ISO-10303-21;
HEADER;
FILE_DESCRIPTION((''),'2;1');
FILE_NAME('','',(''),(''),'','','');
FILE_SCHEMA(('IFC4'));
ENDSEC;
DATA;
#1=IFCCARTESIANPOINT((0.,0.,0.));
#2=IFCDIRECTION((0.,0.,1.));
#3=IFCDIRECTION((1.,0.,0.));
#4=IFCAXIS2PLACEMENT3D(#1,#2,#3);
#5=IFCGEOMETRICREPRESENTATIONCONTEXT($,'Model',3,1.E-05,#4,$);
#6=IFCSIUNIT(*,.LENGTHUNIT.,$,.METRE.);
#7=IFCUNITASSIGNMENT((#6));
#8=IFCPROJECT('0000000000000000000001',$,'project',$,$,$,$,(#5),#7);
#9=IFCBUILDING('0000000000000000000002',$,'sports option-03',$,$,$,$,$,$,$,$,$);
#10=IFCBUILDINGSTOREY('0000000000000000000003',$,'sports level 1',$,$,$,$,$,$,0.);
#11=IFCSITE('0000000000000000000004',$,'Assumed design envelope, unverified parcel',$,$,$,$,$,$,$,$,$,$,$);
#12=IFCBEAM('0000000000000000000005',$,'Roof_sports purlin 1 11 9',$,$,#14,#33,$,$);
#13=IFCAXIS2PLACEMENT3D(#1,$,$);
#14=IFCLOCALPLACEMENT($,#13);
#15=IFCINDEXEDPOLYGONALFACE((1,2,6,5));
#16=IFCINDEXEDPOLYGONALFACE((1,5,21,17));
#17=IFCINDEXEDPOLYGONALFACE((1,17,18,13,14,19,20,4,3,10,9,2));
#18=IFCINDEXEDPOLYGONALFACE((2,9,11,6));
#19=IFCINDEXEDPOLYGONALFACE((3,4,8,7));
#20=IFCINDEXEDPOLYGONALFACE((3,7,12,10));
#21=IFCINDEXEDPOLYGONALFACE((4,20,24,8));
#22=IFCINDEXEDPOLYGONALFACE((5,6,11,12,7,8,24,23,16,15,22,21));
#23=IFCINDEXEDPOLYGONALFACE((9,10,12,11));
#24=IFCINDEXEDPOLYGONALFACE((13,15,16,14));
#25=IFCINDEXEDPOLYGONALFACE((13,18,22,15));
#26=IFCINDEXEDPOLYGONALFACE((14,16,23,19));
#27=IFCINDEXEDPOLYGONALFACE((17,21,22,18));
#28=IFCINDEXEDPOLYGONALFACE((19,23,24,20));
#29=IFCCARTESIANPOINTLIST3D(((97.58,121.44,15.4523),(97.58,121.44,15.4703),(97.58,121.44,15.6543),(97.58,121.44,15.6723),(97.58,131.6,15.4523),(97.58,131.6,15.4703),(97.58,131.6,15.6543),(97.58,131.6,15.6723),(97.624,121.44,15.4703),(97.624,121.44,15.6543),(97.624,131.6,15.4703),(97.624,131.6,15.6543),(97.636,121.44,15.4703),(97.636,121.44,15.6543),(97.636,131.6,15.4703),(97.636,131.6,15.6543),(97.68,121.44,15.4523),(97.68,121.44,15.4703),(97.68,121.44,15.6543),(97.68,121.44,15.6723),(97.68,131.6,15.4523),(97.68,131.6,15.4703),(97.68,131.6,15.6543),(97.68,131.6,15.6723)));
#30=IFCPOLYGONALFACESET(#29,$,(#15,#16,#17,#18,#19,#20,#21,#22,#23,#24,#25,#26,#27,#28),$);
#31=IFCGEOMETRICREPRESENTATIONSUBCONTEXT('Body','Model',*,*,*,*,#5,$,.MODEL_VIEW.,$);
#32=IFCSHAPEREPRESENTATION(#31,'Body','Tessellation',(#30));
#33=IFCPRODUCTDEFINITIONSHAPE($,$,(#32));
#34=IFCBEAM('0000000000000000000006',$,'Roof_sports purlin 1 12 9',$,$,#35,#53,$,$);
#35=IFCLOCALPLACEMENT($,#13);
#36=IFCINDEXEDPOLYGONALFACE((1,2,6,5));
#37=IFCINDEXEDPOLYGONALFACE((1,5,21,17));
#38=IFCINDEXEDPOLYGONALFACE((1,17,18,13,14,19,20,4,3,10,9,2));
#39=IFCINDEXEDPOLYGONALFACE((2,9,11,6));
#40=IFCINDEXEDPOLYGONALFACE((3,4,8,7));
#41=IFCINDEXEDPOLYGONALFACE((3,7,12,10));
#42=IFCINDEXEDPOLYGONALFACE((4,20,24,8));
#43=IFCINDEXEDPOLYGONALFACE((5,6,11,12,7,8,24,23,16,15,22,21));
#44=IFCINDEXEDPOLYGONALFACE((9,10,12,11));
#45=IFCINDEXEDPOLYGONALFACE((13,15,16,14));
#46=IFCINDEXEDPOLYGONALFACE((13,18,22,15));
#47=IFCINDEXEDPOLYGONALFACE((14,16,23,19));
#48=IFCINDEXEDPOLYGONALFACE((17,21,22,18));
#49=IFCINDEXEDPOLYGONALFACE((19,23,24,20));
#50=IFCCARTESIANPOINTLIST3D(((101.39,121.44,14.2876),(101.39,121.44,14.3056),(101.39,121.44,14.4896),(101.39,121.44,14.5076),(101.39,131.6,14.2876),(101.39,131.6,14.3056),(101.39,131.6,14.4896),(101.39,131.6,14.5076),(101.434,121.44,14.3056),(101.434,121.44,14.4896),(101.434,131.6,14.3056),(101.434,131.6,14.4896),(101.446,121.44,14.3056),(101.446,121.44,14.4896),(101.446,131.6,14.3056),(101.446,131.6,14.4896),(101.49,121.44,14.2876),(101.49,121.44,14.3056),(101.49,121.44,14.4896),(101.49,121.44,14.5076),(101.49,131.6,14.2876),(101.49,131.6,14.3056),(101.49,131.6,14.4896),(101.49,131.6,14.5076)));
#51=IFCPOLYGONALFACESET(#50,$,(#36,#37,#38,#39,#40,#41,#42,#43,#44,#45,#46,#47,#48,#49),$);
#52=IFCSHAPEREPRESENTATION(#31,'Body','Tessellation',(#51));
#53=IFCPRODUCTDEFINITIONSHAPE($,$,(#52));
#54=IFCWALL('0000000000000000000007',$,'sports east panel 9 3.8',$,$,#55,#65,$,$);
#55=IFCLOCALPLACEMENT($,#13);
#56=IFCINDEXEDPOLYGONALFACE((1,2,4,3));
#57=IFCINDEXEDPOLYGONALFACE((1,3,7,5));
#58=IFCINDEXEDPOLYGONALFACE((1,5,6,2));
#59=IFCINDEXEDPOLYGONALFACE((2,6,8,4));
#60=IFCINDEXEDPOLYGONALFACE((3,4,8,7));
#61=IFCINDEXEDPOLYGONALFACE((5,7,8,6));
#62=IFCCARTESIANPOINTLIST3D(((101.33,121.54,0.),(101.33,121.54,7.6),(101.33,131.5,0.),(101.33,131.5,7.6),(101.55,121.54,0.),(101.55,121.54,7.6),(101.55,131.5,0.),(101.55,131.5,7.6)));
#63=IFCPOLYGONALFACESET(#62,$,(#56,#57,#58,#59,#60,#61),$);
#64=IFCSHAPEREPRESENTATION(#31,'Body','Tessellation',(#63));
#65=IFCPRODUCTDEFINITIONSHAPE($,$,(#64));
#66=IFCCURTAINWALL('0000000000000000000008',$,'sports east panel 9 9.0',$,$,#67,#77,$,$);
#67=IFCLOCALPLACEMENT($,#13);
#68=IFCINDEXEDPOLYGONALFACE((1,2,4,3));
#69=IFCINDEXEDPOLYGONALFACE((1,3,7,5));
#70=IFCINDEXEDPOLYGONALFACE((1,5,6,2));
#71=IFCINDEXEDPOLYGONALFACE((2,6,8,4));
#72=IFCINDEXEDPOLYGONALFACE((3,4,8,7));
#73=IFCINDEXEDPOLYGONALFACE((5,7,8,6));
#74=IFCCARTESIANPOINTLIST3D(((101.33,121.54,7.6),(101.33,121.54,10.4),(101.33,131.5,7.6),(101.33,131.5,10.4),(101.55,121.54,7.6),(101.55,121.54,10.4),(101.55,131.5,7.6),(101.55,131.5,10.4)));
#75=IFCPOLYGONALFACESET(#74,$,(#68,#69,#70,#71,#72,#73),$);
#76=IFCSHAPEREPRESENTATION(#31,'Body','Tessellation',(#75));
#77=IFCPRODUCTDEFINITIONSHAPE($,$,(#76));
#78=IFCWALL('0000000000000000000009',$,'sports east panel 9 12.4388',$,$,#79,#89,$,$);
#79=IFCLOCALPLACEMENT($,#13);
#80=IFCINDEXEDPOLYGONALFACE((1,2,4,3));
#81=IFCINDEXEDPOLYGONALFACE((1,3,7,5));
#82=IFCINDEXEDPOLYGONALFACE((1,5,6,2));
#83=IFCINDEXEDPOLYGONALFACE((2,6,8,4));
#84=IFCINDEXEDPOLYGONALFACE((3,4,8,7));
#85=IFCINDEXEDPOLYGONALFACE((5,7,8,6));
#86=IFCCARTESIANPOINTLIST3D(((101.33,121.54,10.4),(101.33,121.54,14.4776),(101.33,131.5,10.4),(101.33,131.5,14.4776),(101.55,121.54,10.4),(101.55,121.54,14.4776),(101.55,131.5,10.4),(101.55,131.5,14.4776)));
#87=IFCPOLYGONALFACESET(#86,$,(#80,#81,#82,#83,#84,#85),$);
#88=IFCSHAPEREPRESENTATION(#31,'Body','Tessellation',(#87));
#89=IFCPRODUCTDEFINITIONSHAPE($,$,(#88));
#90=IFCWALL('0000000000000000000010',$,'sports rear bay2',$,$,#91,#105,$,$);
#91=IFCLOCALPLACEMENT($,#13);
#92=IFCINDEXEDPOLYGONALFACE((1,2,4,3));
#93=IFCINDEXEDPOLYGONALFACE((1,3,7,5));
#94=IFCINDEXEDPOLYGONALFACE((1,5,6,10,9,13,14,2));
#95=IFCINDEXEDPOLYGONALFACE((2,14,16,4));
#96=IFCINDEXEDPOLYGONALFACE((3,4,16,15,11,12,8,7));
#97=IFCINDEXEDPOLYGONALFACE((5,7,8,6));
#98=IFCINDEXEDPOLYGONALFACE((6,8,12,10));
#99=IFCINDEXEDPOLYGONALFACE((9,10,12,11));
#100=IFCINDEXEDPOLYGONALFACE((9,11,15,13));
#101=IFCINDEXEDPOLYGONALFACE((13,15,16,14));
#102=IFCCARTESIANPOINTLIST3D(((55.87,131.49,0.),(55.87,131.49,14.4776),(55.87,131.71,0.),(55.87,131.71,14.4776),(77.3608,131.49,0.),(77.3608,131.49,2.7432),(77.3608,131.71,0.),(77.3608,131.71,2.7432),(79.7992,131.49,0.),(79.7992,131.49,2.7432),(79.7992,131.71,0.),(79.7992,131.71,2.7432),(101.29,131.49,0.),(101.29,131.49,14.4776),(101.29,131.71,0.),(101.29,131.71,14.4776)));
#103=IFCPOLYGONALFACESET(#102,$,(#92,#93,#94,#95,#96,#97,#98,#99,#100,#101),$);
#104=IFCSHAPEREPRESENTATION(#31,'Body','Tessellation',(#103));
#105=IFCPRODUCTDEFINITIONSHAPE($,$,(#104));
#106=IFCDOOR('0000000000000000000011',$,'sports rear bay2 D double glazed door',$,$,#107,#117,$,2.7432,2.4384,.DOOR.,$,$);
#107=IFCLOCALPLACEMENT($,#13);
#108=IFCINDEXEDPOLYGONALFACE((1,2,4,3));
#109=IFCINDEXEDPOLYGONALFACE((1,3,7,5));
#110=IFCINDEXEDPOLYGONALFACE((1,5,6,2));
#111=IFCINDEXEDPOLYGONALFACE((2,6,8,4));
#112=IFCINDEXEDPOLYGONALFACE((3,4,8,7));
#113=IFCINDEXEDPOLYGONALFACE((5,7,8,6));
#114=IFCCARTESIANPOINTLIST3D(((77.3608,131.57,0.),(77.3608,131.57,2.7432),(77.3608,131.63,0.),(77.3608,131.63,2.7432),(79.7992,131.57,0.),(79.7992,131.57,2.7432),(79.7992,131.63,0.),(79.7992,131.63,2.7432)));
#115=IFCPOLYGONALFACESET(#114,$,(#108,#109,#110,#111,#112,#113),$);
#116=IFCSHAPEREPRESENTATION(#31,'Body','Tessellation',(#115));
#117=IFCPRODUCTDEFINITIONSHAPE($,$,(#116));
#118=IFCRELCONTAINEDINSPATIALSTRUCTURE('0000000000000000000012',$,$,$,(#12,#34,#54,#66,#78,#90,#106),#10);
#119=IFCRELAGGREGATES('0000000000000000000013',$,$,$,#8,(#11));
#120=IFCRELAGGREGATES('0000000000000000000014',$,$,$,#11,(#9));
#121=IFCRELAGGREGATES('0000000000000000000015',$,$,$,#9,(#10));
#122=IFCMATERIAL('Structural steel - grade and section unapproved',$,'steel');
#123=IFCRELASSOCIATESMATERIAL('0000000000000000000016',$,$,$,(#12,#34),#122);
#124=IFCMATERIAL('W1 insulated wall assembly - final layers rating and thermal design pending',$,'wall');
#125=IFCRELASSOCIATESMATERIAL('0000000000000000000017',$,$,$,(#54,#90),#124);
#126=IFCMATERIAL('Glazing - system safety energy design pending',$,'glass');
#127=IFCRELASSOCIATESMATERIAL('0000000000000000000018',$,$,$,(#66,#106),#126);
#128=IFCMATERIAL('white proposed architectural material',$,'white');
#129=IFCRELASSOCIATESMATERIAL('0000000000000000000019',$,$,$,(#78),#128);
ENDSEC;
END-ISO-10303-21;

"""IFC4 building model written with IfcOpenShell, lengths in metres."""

from ifc_helpers import new_model, si_unit, frame, origin_with_axes, place, context, subcontext, project, spatial, rectangle, i_section, extrude, material, element, fill, save


model = new_model("IFC4")

# Units and contexts
model_context = context("Model", 3, precision=1e-05, world=origin_with_axes())
body_context = subcontext(model_context, "Body", "Model", "MODEL_VIEW")
ifc_project = project(units=[si_unit("LENGTHUNIT", "METRE")], contexts=[model_context])

# Site, building, storey
site = spatial("IfcSite", under=ifc_project, Name="Assumed design envelope, unverified parcel")
building = spatial("IfcBuilding", under=site, Name="sports option-03")
storey = spatial("IfcBuildingStorey", under=building, Name="sports level 1", Elevation=0.0)

# Shared definitions
ifc_material_1 = material(Name="Structural steel - grade and section unapproved", Category="steel")

# Beams
for number, where, z_axis, x_axis, name in (
    (1, (97.63, 121.44, 15.5623), (0.0, 1.0, 0.0), (-1.0, 0.0, 0.0), "Roof_sports purlin 1 11 9"),
    (2, (101.44, 121.44, 14.3976), (0.0, 1.0, 0.0), (-1.0, 0.0, 0.0), "Roof_sports purlin 1 12 9"),
):
    element("IfcBeam", number, at=place(None, frame(where, z_axis=z_axis, x_axis=x_axis)), inside=storey, material=ifc_material_1, Name=name, context=body_context, shape_type="SweptSolid", body=[
        extrude(i_section(OverallWidth=0.1, OverallDepth=0.22, WebThickness=0.012, FlangeThickness=0.018, FilletRadius=0.0), origin_with_axes(), (0.0, 0.0, 1.0), 10.16),
    ])

# Wall
ifc_material_2 = material(Name="W1 insulated wall assembly - final layers rating and thermal design pending", Category="wall")
wall_1_placement = place(None, frame((101.44, 126.52, 0.0), z_axis=(0.0, 0.0, 1.0), x_axis=(1.0, 0.0, 0.0)))
element("IfcWall", 3, at=wall_1_placement, inside=storey, material=ifc_material_2, Name="sports east panel 9 3.8", context=body_context, shape_type="SweptSolid", body=[
    extrude(rectangle(XDim=0.22, YDim=9.96), origin_with_axes(), (0.0, 0.0, 1.0), 7.6),
])

# Curtain wall
ifc_material_3 = material(Name="Glazing - system safety energy design pending", Category="glass")
curtain_wall_placement = place(None, frame((101.44, 126.52, 7.6), z_axis=(0.0, 0.0, 1.0), x_axis=(1.0, 0.0, 0.0)))
element("IfcCurtainWall", 4, at=curtain_wall_placement, inside=storey, material=ifc_material_3, Name="sports east panel 9 9.0", context=body_context, shape_type="SweptSolid", body=[
    extrude(rectangle(XDim=0.22, YDim=9.96), origin_with_axes(), (0.0, 0.0, 1.0), 2.8),
])

# Wall
ifc_material_4 = material(Name="white proposed architectural material", Category="white")
wall_2_placement = place(None, frame((101.44, 126.52, 10.4), z_axis=(0.0, 0.0, 1.0), x_axis=(1.0, 0.0, 0.0)))
element("IfcWall", 5, at=wall_2_placement, inside=storey, material=ifc_material_4, Name="sports east panel 9 12.4388", context=body_context, shape_type="SweptSolid", body=[
    extrude(rectangle(XDim=0.22, YDim=9.96), origin_with_axes(), (0.0, 0.0, 1.0), 4.0776),
])

# Wall, opening, door
wall_3_placement = place(None, frame((78.58, 131.6, 0.0), z_axis=(0.0, 0.0, 1.0), x_axis=(1.0, 0.0, 0.0)))
wall_3 = element("IfcWall", 6, at=wall_3_placement, inside=storey, material=ifc_material_2, Name="sports rear bay2", context=body_context, shape_type="SweptSolid", body=[
    extrude(rectangle(XDim=45.42, YDim=0.22), origin_with_axes(), (0.0, 0.0, 1.0), 14.4776),
])
opening_placement = place(None, frame((78.58, 131.6, 0.0), z_axis=(0.0, 0.0, 1.0), x_axis=(1.0, 0.0, 0.0)))
opening = element("IfcOpeningElement", 7, at=opening_placement, cuts=wall_3, context=body_context, shape_type="SweptSolid", body=[
    extrude(rectangle(XDim=2.4384, YDim=0.32), origin_with_axes(), (0.0, 0.0, 1.0), 2.7432),
])
door_placement = place(None, frame((78.58, 131.6, 0.0), z_axis=(0.0, 0.0, 1.0), x_axis=(1.0, 0.0, 0.0)))
door = element("IfcDoor", 8, at=door_placement, inside=storey, material=ifc_material_3, Name="sports rear bay2 D double glazed door", OverallHeight=2.7432, OverallWidth=2.4384, PredefinedType="DOOR", context=body_context, shape_type="SweptSolid", body=[
    extrude(rectangle(XDim=2.4384, YDim=0.06), origin_with_axes(), (0.0, 0.0, 1.0), 2.7432),
])
fill(opening, door)

save(model, "model.ifc")
